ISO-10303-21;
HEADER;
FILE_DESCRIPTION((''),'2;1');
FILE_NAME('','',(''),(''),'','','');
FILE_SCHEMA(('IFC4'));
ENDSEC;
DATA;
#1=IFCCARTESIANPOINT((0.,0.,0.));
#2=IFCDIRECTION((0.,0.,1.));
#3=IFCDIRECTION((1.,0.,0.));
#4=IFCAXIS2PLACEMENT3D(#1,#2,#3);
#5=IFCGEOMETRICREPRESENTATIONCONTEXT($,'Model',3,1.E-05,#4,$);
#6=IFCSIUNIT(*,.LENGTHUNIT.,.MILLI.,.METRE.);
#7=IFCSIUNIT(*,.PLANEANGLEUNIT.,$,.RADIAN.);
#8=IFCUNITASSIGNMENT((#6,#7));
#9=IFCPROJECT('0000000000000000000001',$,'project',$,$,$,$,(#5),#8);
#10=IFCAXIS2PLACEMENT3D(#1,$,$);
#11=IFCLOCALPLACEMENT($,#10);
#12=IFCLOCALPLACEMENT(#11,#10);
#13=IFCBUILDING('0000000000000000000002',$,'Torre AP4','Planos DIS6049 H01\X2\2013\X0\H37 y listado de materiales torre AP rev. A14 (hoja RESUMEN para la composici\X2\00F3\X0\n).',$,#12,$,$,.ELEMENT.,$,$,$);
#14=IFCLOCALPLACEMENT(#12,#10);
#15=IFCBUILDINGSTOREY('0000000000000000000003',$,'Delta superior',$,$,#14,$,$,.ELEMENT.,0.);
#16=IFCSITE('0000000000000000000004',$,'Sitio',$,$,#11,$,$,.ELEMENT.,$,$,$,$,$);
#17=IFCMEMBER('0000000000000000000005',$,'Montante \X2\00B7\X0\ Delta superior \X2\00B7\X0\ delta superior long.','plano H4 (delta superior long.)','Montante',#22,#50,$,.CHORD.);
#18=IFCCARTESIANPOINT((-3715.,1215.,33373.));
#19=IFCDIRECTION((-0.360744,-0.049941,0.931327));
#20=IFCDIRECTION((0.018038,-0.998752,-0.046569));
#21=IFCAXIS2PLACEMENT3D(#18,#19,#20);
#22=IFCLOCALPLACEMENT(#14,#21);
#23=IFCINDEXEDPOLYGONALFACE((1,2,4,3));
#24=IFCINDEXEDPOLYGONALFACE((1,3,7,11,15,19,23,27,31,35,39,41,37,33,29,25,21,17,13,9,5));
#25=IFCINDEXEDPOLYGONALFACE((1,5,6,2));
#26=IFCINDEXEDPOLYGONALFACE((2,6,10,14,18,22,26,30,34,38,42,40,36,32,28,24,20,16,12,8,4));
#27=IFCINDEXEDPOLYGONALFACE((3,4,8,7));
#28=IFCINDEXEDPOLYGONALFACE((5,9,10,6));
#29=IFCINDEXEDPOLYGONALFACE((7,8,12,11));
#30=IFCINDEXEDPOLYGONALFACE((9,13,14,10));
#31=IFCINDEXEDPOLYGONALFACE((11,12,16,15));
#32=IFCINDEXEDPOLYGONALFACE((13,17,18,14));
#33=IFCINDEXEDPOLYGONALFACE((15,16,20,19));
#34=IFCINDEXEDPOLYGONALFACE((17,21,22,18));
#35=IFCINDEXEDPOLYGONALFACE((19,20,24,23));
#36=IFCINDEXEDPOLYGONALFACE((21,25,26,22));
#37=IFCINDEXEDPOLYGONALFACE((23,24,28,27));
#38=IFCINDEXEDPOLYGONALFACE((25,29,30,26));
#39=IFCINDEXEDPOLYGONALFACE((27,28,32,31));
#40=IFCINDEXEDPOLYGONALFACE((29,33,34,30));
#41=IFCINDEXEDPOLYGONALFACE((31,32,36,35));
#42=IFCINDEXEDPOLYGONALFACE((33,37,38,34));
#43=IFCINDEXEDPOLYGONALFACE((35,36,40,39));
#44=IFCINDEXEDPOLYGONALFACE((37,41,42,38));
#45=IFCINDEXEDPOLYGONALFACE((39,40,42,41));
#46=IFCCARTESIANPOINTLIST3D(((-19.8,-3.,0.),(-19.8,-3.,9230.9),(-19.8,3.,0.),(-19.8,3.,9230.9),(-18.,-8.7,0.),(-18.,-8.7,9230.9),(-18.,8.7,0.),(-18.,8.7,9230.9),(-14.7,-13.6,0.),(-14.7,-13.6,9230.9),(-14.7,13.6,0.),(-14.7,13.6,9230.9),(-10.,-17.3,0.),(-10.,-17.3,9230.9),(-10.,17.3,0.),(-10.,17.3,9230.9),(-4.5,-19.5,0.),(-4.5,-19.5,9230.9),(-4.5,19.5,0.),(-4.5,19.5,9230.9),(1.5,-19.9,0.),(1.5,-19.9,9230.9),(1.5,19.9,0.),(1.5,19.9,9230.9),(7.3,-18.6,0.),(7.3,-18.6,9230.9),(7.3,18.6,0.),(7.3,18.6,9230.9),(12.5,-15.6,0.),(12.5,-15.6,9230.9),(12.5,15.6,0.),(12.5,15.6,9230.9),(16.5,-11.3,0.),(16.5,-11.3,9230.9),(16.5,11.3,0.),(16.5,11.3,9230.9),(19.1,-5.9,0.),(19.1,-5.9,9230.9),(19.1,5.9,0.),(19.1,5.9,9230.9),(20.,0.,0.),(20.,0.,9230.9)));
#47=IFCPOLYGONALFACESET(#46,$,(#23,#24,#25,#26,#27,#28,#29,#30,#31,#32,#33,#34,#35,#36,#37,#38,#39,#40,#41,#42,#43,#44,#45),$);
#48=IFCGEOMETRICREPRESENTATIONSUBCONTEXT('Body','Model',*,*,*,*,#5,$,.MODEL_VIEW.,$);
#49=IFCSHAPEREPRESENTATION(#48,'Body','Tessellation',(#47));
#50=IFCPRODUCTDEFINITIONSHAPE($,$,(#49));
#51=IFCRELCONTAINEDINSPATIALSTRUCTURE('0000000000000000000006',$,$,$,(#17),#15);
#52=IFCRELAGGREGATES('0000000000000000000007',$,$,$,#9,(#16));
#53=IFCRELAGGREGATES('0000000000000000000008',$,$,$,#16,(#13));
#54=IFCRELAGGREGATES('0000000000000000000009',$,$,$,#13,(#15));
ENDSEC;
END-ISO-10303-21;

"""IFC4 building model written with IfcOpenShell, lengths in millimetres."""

from ifc_helpers import new_model, si_unit, frame, origin, origin_with_axes, place, context, subcontext, project, spatial, circle, extrude, element, save


model = new_model("IFC4")

# Units and contexts
model_context = context("Model", 3, precision=1e-05, world=origin_with_axes())
body_context = subcontext(model_context, "Body", "Model", "MODEL_VIEW")
ifc_project = project(units=[si_unit("LENGTHUNIT", "METRE", prefix="MILLI"), si_unit("PLANEANGLEUNIT", "RADIAN")], contexts=[model_context])

# Site, building, storey
site_placement = place(None, origin())
site = spatial("IfcSite", under=ifc_project, at=site_placement, Name="Sitio", CompositionType="ELEMENT")
building_placement = place(site_placement, origin())
building = spatial("IfcBuilding", under=site, at=building_placement, Name="Torre AP4", Description="Planos DIS6049 H01–H37 y listado de materiales torre AP rev. A14 (hoja RESUMEN para la composición).", CompositionType="ELEMENT")
storey_placement = place(building_placement, origin())
storey = spatial("IfcBuildingStorey", under=building, at=storey_placement, Name="Delta superior", CompositionType="ELEMENT", Elevation=0.0)

# Member
for number, where, z_axis, x_axis, name in (
    (1, (-3715.0, 1215.0, 33373.0), (-0.360744, -0.049941, 0.931327), (0.018038, -0.998752, -0.046569), "Montante · Delta superior · delta superior long."),
):
    element("IfcMember", number, at=place(storey_placement, frame(where, z_axis=z_axis, x_axis=x_axis)), inside=storey, Name=name, Description="plano H4 (delta superior long.)", ObjectType="Montante", PredefinedType="CHORD", context=body_context, shape_type="SweptSolid", body=[
        extrude(circle(Radius=20.0), None, (0.0, 0.0, 1.0), 9230.9),
    ])

save(model, "model.ifc")
